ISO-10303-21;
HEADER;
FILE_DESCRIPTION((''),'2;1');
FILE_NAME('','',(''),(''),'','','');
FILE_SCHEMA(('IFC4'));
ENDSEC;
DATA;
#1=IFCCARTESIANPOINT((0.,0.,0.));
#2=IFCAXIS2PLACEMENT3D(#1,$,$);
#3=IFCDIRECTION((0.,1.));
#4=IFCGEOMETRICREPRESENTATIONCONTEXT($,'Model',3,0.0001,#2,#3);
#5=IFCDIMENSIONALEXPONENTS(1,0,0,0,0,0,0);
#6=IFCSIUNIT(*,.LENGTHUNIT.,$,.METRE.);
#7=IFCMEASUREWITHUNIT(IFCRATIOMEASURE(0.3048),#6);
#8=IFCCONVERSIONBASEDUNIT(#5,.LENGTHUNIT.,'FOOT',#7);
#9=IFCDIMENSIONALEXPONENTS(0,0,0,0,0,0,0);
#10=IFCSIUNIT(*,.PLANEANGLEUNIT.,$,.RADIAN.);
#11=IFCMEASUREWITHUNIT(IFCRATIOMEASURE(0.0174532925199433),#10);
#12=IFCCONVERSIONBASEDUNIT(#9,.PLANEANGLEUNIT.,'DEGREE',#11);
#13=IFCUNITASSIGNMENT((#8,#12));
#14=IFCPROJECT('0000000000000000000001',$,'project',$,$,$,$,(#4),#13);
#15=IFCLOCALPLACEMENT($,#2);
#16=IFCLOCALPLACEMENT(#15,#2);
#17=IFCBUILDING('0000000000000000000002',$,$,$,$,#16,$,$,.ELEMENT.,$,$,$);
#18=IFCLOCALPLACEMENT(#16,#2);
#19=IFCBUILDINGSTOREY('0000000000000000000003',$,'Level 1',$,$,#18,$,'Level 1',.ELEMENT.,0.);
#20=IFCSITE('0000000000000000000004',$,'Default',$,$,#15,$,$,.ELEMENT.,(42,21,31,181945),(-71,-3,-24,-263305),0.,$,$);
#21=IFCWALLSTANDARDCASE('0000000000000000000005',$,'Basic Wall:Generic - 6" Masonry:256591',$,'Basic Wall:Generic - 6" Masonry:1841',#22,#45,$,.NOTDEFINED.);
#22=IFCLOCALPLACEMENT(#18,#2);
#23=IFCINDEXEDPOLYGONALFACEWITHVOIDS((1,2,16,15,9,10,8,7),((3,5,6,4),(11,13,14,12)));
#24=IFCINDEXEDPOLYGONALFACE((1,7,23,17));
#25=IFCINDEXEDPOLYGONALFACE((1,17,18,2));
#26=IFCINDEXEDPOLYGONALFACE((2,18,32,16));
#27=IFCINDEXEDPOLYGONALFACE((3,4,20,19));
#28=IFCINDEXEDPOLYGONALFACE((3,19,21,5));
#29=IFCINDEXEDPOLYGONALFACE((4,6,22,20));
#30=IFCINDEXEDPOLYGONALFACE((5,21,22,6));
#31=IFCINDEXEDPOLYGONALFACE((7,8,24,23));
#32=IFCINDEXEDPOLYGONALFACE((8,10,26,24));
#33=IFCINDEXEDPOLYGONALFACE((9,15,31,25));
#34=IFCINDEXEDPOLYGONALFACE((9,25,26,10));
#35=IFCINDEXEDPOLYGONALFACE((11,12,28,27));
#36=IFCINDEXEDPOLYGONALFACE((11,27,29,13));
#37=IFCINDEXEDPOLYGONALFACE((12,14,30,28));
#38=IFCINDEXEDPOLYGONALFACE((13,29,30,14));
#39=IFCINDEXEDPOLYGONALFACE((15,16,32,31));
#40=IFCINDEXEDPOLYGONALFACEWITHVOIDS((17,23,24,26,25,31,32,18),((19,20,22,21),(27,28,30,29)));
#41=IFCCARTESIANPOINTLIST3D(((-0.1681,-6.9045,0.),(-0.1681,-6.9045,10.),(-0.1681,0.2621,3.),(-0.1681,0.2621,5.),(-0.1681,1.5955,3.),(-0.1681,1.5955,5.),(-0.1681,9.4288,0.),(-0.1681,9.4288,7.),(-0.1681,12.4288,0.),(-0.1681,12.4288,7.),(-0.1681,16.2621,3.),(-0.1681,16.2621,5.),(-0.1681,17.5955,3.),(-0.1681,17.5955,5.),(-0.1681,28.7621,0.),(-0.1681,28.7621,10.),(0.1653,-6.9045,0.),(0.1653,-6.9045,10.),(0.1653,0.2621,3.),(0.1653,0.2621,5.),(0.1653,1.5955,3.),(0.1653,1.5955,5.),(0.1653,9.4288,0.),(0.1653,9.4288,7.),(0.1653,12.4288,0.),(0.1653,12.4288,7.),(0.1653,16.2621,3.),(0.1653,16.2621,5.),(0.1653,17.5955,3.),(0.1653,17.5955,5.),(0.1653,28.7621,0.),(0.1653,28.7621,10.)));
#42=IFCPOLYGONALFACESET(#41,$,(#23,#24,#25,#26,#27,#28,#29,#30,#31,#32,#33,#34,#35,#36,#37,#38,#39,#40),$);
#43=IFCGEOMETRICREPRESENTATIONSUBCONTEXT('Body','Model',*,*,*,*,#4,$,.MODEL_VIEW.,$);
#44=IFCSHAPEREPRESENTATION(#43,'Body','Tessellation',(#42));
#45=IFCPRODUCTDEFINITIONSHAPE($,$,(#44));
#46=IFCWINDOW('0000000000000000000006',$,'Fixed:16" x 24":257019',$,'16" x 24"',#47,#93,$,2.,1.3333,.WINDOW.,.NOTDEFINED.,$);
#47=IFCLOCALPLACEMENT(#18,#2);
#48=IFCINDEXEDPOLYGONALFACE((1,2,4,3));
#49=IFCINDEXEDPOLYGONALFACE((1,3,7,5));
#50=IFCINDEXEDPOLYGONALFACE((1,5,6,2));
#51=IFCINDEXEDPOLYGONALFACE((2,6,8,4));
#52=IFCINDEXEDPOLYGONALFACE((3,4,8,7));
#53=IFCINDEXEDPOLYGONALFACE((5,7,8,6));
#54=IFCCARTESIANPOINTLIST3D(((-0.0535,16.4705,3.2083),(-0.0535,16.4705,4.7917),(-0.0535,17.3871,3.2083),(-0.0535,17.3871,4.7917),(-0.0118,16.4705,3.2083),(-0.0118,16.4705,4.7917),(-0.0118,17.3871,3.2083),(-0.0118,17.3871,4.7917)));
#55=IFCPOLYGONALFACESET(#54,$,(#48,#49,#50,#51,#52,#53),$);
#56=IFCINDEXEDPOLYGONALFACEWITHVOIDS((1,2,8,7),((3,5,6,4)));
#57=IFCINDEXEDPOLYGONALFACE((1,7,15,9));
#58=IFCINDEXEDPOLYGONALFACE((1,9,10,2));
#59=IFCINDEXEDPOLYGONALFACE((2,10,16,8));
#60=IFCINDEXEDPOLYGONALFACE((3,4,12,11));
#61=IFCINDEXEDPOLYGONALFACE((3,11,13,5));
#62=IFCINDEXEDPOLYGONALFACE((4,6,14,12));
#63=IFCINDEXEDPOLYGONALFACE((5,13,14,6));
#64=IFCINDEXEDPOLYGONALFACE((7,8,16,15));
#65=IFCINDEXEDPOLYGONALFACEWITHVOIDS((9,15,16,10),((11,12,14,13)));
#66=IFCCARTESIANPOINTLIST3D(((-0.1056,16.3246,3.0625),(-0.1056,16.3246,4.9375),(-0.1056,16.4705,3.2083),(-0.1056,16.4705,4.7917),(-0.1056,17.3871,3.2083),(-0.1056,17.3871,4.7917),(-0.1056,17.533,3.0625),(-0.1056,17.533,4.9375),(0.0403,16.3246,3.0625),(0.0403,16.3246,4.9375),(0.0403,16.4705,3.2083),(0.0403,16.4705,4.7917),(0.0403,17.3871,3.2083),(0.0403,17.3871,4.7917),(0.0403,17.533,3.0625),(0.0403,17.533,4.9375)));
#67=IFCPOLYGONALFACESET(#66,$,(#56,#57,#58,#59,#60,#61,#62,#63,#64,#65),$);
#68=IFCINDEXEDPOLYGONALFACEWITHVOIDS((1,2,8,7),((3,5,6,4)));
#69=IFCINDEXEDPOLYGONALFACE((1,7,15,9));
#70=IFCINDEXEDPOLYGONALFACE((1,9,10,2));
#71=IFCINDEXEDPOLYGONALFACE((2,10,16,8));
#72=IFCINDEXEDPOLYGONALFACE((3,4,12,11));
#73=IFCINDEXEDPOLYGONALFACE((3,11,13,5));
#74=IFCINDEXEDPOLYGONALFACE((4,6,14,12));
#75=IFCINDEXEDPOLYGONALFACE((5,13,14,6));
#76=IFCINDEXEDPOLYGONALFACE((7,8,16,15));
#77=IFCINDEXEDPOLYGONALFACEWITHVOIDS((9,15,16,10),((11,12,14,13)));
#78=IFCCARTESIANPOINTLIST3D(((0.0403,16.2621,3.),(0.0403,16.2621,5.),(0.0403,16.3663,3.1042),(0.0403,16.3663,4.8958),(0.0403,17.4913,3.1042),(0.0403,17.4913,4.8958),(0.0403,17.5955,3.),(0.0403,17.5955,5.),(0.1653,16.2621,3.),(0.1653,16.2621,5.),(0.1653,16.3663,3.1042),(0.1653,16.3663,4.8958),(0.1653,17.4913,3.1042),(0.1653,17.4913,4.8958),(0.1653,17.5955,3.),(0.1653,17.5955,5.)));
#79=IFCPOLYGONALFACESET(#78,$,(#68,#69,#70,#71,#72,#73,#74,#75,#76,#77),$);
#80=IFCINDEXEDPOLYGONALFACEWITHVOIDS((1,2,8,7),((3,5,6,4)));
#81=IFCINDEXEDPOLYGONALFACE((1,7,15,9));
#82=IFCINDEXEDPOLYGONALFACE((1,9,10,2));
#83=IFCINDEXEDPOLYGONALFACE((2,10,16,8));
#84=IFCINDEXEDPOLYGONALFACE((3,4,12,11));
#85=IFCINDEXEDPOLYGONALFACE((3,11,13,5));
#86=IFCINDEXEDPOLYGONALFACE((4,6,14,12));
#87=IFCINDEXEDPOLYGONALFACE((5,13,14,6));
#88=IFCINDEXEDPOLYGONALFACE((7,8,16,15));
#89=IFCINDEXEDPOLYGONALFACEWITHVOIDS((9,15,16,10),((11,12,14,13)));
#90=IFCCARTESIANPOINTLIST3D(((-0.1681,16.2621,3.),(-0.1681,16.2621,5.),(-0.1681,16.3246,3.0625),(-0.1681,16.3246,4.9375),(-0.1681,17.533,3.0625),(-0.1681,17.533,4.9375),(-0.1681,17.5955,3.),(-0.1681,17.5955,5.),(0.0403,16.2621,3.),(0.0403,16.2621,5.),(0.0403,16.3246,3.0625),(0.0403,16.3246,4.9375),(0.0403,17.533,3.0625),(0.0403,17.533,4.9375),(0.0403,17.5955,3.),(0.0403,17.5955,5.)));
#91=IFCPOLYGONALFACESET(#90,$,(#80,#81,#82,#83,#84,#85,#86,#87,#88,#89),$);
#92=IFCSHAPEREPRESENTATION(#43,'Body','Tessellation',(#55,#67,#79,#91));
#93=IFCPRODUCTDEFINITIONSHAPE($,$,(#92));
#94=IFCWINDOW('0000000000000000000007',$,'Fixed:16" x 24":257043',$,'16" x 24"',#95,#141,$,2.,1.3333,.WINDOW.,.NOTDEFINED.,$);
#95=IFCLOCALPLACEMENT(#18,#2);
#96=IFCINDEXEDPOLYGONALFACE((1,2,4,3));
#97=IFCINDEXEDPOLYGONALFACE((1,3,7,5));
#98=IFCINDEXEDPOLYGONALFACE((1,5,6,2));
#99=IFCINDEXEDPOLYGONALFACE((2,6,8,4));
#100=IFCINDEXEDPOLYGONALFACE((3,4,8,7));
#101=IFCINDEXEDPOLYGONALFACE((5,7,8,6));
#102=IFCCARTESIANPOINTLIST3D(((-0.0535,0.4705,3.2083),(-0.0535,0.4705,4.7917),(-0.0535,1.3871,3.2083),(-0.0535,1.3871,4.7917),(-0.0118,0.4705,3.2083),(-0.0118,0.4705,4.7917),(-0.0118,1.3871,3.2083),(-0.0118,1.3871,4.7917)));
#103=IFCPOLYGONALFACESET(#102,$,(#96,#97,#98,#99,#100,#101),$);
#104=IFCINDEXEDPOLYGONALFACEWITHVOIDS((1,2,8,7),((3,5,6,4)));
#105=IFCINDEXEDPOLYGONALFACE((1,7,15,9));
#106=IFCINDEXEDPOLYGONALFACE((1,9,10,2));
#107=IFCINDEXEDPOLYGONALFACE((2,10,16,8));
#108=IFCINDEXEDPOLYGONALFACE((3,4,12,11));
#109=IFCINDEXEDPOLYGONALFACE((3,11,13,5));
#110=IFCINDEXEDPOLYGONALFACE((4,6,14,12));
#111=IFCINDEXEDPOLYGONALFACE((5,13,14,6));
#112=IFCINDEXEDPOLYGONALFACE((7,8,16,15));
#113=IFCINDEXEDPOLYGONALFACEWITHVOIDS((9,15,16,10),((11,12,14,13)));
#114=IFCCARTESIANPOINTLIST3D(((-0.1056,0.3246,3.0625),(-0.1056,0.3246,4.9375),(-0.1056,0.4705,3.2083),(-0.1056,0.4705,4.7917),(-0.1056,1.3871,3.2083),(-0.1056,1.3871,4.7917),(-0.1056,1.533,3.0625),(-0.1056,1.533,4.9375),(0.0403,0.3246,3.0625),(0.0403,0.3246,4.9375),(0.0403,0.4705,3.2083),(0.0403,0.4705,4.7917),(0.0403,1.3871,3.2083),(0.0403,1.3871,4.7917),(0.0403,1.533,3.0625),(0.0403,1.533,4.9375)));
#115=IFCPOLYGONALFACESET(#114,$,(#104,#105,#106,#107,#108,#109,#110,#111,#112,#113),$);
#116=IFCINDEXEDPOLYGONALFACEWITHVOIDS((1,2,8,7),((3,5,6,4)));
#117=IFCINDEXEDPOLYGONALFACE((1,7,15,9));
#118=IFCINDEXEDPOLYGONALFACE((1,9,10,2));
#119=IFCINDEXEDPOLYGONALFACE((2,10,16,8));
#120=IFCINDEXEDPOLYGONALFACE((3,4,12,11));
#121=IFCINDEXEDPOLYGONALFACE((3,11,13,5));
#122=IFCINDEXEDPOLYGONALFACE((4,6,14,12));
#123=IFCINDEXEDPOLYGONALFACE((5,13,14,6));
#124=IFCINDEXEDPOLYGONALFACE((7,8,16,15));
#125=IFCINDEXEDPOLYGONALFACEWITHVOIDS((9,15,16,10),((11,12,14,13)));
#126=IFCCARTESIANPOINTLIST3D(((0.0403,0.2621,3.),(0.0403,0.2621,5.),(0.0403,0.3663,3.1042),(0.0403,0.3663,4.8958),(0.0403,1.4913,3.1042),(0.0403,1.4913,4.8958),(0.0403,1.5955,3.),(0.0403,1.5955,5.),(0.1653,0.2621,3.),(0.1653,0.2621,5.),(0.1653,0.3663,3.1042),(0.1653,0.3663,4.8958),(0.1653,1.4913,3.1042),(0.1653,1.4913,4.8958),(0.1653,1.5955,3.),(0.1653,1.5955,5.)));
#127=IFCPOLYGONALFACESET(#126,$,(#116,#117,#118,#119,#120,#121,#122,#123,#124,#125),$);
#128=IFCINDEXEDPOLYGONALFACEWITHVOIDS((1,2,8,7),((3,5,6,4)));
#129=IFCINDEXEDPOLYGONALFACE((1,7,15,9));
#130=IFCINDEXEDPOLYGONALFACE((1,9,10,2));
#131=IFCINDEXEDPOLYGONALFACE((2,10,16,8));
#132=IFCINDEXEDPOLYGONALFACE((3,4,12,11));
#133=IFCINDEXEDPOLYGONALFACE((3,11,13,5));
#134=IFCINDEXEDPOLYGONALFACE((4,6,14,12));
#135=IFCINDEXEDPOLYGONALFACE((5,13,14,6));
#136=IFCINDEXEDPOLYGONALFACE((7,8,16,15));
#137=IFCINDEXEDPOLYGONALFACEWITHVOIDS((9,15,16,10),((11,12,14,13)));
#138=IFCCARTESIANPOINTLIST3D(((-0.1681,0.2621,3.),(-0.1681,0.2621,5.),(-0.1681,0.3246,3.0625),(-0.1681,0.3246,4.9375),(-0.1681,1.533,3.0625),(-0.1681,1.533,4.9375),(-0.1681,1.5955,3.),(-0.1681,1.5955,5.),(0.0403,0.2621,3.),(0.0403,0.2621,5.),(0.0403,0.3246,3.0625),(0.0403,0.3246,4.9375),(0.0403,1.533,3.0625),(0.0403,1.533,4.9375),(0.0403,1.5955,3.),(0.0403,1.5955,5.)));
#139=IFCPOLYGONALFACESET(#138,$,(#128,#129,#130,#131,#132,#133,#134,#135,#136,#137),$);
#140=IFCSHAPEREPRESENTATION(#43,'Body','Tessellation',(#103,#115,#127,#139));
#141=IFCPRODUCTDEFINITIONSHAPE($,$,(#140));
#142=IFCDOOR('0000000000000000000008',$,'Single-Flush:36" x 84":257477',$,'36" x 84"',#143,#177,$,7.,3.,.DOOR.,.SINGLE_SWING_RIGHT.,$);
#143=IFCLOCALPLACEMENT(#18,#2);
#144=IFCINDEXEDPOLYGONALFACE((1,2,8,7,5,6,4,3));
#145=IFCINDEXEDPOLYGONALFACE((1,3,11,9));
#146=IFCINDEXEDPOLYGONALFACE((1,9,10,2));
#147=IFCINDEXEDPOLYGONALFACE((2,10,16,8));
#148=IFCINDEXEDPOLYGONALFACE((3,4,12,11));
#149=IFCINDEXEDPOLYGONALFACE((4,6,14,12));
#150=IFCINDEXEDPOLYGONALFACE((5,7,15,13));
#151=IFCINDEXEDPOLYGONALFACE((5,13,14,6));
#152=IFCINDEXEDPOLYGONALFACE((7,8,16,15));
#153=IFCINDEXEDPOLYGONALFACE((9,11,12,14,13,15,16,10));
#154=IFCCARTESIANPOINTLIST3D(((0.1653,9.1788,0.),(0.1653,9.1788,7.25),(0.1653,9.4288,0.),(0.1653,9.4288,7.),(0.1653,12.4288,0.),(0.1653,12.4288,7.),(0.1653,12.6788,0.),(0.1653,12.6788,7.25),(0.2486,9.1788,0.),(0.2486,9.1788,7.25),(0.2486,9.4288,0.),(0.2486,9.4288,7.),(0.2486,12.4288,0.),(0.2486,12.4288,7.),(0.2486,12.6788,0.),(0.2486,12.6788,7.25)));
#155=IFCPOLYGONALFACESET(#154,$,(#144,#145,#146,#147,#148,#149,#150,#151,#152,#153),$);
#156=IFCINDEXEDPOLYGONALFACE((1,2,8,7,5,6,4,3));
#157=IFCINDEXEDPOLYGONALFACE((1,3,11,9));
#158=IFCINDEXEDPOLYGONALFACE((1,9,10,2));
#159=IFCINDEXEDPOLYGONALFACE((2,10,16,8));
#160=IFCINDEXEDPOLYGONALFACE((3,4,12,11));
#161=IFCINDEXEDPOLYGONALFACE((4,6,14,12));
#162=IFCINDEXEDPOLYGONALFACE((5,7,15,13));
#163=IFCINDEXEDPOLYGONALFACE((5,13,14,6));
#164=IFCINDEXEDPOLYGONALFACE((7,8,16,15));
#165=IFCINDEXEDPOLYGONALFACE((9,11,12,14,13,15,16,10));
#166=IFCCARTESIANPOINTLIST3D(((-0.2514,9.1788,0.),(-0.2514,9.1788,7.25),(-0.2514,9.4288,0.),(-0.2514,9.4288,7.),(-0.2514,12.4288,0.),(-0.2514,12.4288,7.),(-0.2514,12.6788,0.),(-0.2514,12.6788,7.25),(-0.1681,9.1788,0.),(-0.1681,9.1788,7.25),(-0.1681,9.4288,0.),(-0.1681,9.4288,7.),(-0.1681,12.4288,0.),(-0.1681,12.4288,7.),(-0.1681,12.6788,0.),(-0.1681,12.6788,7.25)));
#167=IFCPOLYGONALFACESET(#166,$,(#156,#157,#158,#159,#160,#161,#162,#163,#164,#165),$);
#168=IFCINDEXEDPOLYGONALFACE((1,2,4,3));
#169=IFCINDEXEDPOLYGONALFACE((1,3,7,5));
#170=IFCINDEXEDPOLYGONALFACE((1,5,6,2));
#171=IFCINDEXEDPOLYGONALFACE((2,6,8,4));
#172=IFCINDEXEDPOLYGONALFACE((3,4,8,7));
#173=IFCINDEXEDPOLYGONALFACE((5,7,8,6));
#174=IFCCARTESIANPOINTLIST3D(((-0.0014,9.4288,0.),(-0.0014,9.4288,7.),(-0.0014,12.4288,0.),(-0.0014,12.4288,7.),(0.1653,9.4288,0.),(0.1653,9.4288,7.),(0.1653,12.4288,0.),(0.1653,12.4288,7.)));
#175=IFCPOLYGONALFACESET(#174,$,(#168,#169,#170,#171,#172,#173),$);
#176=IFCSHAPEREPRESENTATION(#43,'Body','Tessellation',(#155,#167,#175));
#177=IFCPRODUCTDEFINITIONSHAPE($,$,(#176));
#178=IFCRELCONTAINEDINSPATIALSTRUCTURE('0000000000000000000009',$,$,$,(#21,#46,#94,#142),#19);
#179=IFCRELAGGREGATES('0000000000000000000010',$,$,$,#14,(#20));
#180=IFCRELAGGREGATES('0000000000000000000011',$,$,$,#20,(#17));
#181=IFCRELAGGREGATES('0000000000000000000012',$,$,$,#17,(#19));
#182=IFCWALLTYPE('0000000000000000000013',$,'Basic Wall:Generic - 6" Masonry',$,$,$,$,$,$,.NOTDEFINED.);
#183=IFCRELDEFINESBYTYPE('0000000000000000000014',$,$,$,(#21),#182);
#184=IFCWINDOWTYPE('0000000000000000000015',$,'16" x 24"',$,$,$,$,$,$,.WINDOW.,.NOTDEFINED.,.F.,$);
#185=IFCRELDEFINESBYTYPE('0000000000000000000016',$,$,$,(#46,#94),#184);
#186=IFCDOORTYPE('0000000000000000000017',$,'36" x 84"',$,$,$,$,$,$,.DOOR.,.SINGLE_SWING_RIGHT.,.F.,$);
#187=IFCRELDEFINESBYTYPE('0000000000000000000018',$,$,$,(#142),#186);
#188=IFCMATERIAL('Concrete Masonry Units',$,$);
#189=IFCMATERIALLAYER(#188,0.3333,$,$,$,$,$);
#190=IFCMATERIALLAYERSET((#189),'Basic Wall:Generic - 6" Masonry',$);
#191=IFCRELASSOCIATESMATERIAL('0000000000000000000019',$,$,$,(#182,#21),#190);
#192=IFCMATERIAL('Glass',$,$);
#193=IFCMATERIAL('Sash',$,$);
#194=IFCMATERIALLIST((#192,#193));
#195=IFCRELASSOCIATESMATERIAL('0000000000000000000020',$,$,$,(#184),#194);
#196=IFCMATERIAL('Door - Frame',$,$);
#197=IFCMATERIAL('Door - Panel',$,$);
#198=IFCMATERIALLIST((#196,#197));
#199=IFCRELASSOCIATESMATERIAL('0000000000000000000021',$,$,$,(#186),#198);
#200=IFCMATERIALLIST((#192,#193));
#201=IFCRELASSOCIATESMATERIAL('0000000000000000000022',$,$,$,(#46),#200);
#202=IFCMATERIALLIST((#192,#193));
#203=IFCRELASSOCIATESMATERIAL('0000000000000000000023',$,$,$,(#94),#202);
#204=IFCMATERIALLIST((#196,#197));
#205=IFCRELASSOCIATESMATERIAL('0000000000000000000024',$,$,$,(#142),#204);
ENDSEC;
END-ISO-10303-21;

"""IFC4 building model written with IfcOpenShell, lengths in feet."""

from ifc_helpers import new_model, entity, si_unit, converted_unit, direction, frame, frame_2d, origin, origin_2d_with_axis, place, context, subcontext, project, spatial, polyline, rectangle, outline, extrude, source, transform, mapped, material, material_list, layer, layer_set, layer_usage, type_object, type_shapes, element, fill, save


model = new_model("IFC4")

# Units and contexts
model_context = context("Model", 3, precision=0.0001, world=origin(), true_north=direction((0.0, 1.0)))
body_context = subcontext(model_context, "Body", "Model", "MODEL_VIEW")
ifc_project = project(units=[converted_unit("LENGTHUNIT", "FOOT", entity("IfcRatioMeasure", 0.3048), si_unit("LENGTHUNIT", "METRE"), dimensions=[1, 0, 0, 0, 0, 0, 0]), converted_unit("PLANEANGLEUNIT", "DEGREE", entity("IfcRatioMeasure", 0.0174532925199433), si_unit("PLANEANGLEUNIT", "RADIAN"), dimensions=[0, 0, 0, 0, 0, 0, 0])], contexts=[model_context])

# Site, building, storey
site_placement = place(None, origin())
site = spatial("IfcSite", under=ifc_project, at=site_placement, Name="Default", CompositionType="ELEMENT", RefLatitude=(42, 21, 31, 181945), RefLongitude=(-71, -3, -24, -263305), RefElevation=0.0)
building_placement = place(site_placement, origin())
building = spatial("IfcBuilding", under=site, at=building_placement, CompositionType="ELEMENT")
storey_placement = place(building_placement, origin())
storey = spatial("IfcBuildingStorey", under=building, at=storey_placement, Name="Level 1", LongName="Level 1", CompositionType="ELEMENT", Elevation=0.0)

# Shared definitions
ifc_material_1 = material(Name="Concrete Masonry Units")
ifc_layer = layer(ifc_material_1, 0.3333)
ifc_layer_set = layer_set([ifc_layer], Name="Basic Wall:Generic - 6\" Masonry")
wall_type = type_object("IfcWallType", Name="Basic Wall:Generic - 6\" Masonry", PredefinedType="NOTDEFINED", material=ifc_layer_set)
ifc_material_2 = material(Name="Glass")
ifc_material_3 = material(Name="Sash")
ifc_material_list_1 = material_list([ifc_material_2, ifc_material_3])
window_type = type_object("IfcWindowType", Name="16\" x 24\"", ParameterTakesPrecedence=False, PartitioningType="NOTDEFINED", PredefinedType="WINDOW", material=ifc_material_list_1)
shared_shape_1 = source(origin(), body_context, "Body", "SweptSolid", [
    extrude(rectangle(XDim=0.0417, YDim=0.9167, at=origin_2d_with_axis()), frame((0.6667, 0.1979, 0.2083), z_axis=(0.0, 0.0, 1.0), x_axis=(0.0, 1.0, 0.0)), (0.0, 0.0, 1.0), 1.5833),
    extrude(outline(polyline([(-0.6042, -0.9375), (0.6042, -0.9375), (0.6042, 0.9375), (-0.6042, 0.9375), (-0.6042, -0.9375)]), holes=[polyline([(-0.4583, -0.7917), (-0.4583, 0.7917), (0.4583, 0.7917), (0.4583, -0.7917), (-0.4583, -0.7917)])]), frame((0.6667, 0.125, 1.0), z_axis=(0.0, 1.0, 0.0), x_axis=(1.0, 0.0, 0.0)), (0.0, 0.0, 1.0), 0.1458),
    extrude(outline(polyline([(-0.6667, -1.0), (0.6667, -1.0), (0.6667, 1.0), (-0.6667, 1.0), (-0.6667, -1.0)]), holes=[polyline([(-0.5625, -0.8958), (-0.5625, 0.8958), (0.5625, 0.8958), (0.5625, -0.8958), (-0.5625, -0.8958)])]), frame((0.6667, 0.0, 1.0), z_axis=(0.0, 1.0, 0.0), x_axis=(1.0, 0.0, 0.0)), (0.0, 0.0, 1.0), 0.125),
    extrude(outline(polyline([(-1.0, -0.6667), (1.0, -0.6667), (1.0, 0.6667), (-1.0, 0.6667), (-1.0, -0.6667)]), holes=[polyline([(-0.9375, -0.6042), (-0.9375, 0.6042), (0.9375, 0.6042), (0.9375, -0.6042), (-0.9375, -0.6042)])]), frame((0.6667, 0.125, 1.0), z_axis=(0.0, 1.0, 0.0), x_axis=(0.0, 0.0, -1.0)), (0.0, 0.0, 1.0), 0.2083),
])
type_shapes(window_type, [shared_shape_1])
ifc_material_4 = material(Name="Door - Frame")
ifc_material_5 = material(Name="Door - Panel")
ifc_material_list_2 = material_list([ifc_material_4, ifc_material_5])
door_type = type_object("IfcDoorType", Name="36\" x 84\"", OperationType="SINGLE_SWING_RIGHT", ParameterTakesPrecedence=False, PredefinedType="DOOR", material=ifc_material_list_2)
shared_shape_2 = source(origin(), body_context, "Body", "SweptSolid", [
    extrude(outline(polyline([(-1.75, -3.6875), (1.75, -3.6875), (1.75, 3.5625), (1.5, 3.5625), (1.5, -3.4375), (-1.5, -3.4375), (-1.5, 3.5625), (-1.75, 3.5625), (-1.75, -3.6875)])), frame((1.5, 0.3333, 3.5625), z_axis=(0.0, 1.0, 0.0), x_axis=(1.0, 0.0, 0.0)), (0.0, 0.0, 1.0), 0.0833),
    extrude(outline(polyline([(-3.6875, -1.75), (3.5625, -1.75), (3.5625, -1.5), (-3.4375, -1.5), (-3.4375, 1.5), (3.5625, 1.5), (3.5625, 1.75), (-3.6875, 1.75), (-3.6875, -1.75)])), frame((1.5, -0.0833, 3.5625), z_axis=(0.0, 1.0, 0.0), x_axis=(0.0, 0.0, -1.0)), (0.0, 0.0, 1.0), 0.0833),
    extrude(rectangle(XDim=0.1667, YDim=3.0, at=frame_2d((0.0, 0.0), x_axis=(1.0, 0.0))), frame((1.5, 0.25, 0.0), z_axis=(0.0, 0.0, 1.0), x_axis=(0.0, 1.0, 0.0)), (0.0, 0.0, 1.0), 7.0),
])
type_shapes(door_type, [shared_shape_2])

# Wall, openings, windows, door
ifc_layer_usage_1 = layer_usage(ifc_layer_set, "AXIS2", "NEGATIVE", 0.1667)
wall_1_placement = place(storey_placement, frame((-0.0014, -6.9045, 0.0), z_axis=(0.0, 0.0, 1.0), x_axis=(0.0, 1.0, 0.0)))
wall_1 = element("IfcWallStandardCase", 1, at=wall_1_placement, inside=storey, type_object=wall_type, material=ifc_layer_usage_1, Name="Basic Wall:Generic - 6\" Masonry:256591", ObjectType="Basic Wall:Generic - 6\" Masonry:1841", PredefinedType="NOTDEFINED", context=body_context, shape_type="SweptSolid", body=[
    extrude(rectangle(XDim=35.6667, YDim=0.3333, at=frame_2d((17.8333, 0.0), x_axis=(-1.0, 0.0))), origin(), (0.0, 0.0, 1.0), 10.0),
])
opening_1_placement = place(wall_1_placement, frame((19.3333, 0.1667, 0.0)))
opening_1 = element("IfcOpeningElement", 2, at=opening_1_placement, cuts=wall_1, ObjectType="Opening", PredefinedType="OPENING", context=body_context, shape_type="SweptSolid", body=[
    extrude(rectangle(XDim=3.0, YDim=7.0, at=frame_2d((3.5, 1.5), x_axis=(0.0, 1.0))), frame((0.0, 0.0, 0.0), z_axis=(0.0, -1.0, 0.0), x_axis=(0.0, 0.0, 1.0)), (0.0, 0.0, 1.0), 0.3333),
])
opening_2_placement = place(wall_1_placement, frame((23.1667, -0.1667, 3.0)))
opening_2 = element("IfcOpeningElement", 3, at=opening_2_placement, cuts=wall_1, ObjectType="Opening", PredefinedType="OPENING", context=body_context, shape_type="SweptSolid", body=[
    extrude(rectangle(XDim=2.0, YDim=1.3333, at=frame_2d((1.0, 0.6667), x_axis=(-1.0, 0.0))), frame((0.0, 0.0, 0.0), z_axis=(0.0, 1.0, 0.0), x_axis=(0.0, 0.0, 1.0)), (0.0, 0.0, 1.0), 0.3333),
])
opening_3_placement = place(wall_1_placement, frame((7.1667, -0.1667, 3.0)))
opening_3 = element("IfcOpeningElement", 4, at=opening_3_placement, cuts=wall_1, ObjectType="Opening", PredefinedType="OPENING", context=body_context, shape_type="SweptSolid", body=[
    extrude(rectangle(XDim=2.0, YDim=1.3333, at=frame_2d((1.0, 0.6667), x_axis=(-1.0, 0.0))), frame((0.0, 0.0, 0.0), z_axis=(0.0, 1.0, 0.0), x_axis=(0.0, 0.0, 1.0)), (0.0, 0.0, 1.0), 0.3333),
])
ifc_material_list_3 = material_list([ifc_material_2, ifc_material_3])
window_1_placement = place(opening_2_placement, origin())
window_1 = element("IfcWindow", 5, at=window_1_placement, inside=storey, type_object=window_type, material=ifc_material_list_3, Name="Fixed:16\" x 24\":257019", ObjectType="16\" x 24\"", OverallHeight=2.0, OverallWidth=1.3333, PartitioningType="NOTDEFINED", PredefinedType="WINDOW", context=body_context, shape_type="MappedRepresentation", body=[
    mapped(shared_shape_1, transform((0.0, 0.0, 0.0), scale=1.0)),
])
fill(opening_2, window_1)
ifc_material_list_4 = material_list([ifc_material_2, ifc_material_3])
window_2_placement = place(opening_3_placement, origin())
window_2 = element("IfcWindow", 6, at=window_2_placement, inside=storey, type_object=window_type, material=ifc_material_list_4, Name="Fixed:16\" x 24\":257043", ObjectType="16\" x 24\"", OverallHeight=2.0, OverallWidth=1.3333, PartitioningType="NOTDEFINED", PredefinedType="WINDOW", context=body_context, shape_type="MappedRepresentation", body=[
    mapped(shared_shape_1, transform((0.0, 0.0, 0.0), scale=1.0)),
])
fill(opening_3, window_2)
ifc_material_list_5 = material_list([ifc_material_4, ifc_material_5])
door_1_placement = place(opening_1_placement, frame((0.0, 0.0, 0.0), z_axis=(0.0, 0.0, 1.0), x_axis=(-1.0, 0.0, 0.0)))
door_1 = element("IfcDoor", 7, at=door_1_placement, inside=storey, type_object=door_type, material=ifc_material_list_5, Name="Single-Flush:36\" x 84\":257477", ObjectType="36\" x 84\"", OperationType="SINGLE_SWING_RIGHT", OverallHeight=7.0, OverallWidth=3.0, PredefinedType="DOOR", context=body_context, shape_type="MappedRepresentation", body=[
    mapped(shared_shape_2, transform((0.0, 0.0, 0.0), scale=1.0)),
])
fill(opening_1, door_1)

save(model, "model.ifc")
